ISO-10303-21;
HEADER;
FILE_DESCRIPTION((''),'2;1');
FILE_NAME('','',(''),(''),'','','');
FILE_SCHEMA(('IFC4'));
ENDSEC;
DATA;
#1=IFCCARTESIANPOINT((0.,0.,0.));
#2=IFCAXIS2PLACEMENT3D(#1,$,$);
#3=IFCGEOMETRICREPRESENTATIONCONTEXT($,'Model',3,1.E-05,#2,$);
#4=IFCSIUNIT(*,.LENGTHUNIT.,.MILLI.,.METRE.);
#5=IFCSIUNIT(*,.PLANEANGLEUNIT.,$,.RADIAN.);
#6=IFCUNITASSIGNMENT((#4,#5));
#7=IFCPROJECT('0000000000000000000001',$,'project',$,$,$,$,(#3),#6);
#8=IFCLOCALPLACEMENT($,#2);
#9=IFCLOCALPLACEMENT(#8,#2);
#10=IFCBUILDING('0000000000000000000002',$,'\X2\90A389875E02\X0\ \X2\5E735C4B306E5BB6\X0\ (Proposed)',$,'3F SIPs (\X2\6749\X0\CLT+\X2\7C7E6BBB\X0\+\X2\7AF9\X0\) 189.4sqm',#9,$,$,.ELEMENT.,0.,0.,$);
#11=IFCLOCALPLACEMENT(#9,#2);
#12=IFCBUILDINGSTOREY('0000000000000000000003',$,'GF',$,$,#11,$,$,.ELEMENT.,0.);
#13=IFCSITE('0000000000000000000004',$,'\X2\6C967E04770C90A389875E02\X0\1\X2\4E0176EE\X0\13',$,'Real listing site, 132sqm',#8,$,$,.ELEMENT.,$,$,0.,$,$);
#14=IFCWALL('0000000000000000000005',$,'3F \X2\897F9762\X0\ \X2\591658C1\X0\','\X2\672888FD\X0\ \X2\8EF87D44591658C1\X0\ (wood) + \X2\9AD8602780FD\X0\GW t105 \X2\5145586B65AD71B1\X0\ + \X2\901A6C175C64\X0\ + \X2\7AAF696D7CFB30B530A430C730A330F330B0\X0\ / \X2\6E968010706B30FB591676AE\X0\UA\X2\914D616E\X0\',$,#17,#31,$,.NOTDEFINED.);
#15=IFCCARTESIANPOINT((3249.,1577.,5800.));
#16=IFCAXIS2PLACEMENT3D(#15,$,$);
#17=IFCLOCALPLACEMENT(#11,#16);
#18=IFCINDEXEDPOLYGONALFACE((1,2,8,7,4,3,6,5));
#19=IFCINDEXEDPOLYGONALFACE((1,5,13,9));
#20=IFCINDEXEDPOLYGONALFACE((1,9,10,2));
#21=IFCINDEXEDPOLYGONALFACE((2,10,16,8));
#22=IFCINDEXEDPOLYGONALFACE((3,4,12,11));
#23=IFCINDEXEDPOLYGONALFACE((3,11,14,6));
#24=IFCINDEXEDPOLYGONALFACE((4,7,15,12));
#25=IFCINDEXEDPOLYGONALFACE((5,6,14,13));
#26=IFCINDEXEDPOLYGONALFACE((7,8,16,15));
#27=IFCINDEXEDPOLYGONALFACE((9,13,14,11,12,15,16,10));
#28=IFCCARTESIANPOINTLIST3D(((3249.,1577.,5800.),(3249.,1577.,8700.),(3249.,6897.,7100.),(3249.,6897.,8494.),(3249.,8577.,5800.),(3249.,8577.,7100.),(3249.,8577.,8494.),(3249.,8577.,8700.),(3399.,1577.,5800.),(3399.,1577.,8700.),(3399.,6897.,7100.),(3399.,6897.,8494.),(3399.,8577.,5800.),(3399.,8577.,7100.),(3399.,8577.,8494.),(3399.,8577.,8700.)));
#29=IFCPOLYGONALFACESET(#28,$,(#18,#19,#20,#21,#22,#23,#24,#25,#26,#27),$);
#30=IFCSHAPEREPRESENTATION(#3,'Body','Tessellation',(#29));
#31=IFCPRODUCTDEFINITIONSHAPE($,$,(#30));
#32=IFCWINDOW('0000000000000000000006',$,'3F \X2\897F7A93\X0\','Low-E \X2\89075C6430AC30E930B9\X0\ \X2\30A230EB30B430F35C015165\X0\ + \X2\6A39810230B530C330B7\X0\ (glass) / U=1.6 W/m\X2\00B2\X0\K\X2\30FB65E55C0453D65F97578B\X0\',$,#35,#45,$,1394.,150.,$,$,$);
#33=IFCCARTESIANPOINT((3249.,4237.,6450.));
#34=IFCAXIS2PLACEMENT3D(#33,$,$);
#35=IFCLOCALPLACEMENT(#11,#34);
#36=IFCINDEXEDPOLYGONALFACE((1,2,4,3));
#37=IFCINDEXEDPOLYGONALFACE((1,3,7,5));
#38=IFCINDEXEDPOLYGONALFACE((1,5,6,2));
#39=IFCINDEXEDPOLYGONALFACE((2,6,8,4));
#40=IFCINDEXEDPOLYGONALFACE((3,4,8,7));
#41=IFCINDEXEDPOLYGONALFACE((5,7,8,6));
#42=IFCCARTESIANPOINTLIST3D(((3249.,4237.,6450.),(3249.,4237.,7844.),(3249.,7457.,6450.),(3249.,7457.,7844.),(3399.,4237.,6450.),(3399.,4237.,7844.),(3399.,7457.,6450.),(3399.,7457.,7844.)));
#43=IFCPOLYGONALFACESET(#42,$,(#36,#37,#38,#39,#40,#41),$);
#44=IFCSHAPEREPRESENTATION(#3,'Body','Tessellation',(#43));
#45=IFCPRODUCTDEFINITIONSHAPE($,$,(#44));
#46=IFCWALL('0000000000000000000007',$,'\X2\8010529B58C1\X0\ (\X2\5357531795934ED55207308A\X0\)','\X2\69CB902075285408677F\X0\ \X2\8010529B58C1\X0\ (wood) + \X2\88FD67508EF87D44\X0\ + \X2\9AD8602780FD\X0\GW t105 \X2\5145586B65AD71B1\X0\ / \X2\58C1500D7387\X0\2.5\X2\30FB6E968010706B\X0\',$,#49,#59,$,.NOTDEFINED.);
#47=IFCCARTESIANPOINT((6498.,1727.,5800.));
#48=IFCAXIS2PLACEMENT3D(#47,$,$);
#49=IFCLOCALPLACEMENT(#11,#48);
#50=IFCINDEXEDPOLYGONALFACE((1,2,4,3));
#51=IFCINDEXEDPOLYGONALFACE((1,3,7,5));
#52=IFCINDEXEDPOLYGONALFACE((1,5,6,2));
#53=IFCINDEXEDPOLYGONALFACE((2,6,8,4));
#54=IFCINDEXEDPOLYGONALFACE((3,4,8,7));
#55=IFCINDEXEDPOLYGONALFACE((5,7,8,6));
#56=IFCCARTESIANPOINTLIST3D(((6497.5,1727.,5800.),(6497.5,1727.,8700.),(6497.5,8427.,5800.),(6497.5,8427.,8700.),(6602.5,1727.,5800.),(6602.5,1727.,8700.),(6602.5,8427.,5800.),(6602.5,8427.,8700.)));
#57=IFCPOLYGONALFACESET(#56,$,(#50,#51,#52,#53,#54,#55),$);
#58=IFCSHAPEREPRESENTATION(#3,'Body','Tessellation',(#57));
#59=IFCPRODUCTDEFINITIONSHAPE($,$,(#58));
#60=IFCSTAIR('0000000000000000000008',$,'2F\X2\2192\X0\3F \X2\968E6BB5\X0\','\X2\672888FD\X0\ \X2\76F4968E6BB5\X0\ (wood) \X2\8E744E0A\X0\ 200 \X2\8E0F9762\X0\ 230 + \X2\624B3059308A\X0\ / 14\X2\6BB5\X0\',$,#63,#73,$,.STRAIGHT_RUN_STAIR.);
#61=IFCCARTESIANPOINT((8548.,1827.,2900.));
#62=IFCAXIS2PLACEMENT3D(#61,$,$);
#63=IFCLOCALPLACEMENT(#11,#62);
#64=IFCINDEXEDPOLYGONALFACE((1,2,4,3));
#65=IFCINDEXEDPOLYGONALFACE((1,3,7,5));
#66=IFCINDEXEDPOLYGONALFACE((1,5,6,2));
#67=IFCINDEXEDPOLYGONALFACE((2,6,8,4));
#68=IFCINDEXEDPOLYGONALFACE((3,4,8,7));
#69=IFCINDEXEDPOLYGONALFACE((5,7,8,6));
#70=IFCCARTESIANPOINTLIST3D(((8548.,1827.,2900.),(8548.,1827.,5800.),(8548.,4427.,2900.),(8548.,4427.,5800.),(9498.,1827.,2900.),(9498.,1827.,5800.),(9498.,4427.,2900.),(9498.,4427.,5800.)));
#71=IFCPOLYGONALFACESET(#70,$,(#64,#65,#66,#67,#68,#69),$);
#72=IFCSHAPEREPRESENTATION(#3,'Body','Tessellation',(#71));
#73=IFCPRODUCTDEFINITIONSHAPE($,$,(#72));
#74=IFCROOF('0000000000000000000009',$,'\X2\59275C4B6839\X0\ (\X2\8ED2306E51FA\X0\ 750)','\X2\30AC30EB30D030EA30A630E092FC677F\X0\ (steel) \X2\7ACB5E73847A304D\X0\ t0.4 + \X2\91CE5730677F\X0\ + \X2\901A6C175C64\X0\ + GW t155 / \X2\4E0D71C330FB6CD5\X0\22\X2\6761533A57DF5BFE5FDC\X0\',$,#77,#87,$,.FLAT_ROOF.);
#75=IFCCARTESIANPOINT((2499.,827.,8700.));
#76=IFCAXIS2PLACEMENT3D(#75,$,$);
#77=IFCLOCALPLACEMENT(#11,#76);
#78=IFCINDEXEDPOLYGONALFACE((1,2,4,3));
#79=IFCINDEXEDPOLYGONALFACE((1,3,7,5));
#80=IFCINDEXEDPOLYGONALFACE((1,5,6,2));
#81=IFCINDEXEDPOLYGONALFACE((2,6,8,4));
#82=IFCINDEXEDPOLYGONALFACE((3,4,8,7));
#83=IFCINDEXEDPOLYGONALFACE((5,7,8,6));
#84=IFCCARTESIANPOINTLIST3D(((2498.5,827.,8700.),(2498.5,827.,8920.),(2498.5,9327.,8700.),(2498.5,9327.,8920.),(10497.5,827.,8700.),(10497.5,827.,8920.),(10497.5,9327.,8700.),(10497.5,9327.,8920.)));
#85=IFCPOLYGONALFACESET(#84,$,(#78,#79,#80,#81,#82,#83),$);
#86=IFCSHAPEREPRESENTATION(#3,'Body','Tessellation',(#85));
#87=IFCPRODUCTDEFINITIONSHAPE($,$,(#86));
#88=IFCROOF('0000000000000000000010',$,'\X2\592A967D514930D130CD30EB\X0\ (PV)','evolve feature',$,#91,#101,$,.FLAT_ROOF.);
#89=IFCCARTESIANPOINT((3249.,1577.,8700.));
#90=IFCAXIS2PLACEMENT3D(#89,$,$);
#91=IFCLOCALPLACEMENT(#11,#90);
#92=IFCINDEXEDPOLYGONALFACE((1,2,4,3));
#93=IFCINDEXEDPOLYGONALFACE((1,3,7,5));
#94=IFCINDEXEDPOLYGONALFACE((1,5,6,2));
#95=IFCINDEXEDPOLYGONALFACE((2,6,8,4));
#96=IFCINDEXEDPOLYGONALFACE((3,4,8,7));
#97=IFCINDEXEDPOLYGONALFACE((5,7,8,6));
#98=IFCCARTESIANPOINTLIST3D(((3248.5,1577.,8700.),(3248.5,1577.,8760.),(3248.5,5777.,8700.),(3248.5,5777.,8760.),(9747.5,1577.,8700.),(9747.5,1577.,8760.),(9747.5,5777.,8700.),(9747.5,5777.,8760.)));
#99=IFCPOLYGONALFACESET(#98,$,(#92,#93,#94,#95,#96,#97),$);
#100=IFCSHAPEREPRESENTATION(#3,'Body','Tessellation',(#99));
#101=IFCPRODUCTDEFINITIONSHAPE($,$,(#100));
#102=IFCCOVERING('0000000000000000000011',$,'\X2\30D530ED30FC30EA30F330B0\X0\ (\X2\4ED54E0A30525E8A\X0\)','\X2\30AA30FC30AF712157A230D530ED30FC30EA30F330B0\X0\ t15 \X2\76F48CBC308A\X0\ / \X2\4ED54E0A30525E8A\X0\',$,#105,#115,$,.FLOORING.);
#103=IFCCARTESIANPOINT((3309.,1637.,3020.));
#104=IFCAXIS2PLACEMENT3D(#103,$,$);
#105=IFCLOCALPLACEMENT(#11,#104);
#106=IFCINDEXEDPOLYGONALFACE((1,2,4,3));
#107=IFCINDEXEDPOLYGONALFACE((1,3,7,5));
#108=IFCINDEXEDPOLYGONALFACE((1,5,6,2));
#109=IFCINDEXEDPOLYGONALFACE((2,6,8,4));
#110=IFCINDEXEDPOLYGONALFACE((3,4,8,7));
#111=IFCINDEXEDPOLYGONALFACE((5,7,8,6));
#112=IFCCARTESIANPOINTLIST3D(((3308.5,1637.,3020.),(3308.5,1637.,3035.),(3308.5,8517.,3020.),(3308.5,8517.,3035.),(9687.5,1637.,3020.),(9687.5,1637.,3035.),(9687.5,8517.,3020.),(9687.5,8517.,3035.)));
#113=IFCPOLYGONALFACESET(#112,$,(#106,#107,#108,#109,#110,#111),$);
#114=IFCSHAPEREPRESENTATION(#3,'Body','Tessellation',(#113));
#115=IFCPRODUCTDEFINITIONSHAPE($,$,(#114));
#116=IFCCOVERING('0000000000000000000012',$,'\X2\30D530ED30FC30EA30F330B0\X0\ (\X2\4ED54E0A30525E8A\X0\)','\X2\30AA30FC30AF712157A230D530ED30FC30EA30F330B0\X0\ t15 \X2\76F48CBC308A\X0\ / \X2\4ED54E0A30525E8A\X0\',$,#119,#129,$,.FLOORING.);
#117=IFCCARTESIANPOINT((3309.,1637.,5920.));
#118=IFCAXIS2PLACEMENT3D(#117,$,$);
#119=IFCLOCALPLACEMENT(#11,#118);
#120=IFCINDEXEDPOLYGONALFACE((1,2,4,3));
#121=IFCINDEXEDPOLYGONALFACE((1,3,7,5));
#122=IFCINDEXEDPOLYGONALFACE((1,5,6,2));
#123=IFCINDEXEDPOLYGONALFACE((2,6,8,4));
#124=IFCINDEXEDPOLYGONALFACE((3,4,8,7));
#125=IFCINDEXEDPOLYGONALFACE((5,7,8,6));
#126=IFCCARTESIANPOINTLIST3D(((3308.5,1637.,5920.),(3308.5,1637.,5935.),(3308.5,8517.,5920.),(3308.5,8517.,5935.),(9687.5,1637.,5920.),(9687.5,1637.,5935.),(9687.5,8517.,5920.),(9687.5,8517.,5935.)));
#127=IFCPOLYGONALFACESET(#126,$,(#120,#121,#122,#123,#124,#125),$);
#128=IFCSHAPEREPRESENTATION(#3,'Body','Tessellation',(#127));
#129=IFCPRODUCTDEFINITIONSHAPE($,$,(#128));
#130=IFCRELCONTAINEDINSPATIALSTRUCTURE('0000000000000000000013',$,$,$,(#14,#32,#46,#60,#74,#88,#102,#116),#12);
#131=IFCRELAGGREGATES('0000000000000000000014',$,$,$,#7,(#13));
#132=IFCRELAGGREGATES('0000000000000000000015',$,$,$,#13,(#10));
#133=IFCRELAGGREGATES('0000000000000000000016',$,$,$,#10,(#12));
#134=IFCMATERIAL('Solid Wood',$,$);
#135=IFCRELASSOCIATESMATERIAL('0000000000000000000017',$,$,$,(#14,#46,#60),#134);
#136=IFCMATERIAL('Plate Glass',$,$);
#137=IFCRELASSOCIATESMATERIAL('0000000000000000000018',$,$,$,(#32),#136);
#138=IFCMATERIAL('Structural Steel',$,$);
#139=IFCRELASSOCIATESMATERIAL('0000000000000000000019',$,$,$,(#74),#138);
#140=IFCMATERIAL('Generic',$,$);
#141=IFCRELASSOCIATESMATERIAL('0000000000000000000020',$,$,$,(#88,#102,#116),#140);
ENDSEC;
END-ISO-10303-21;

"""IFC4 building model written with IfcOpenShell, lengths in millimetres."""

from ifc_helpers import new_model, si_unit, frame, frame_2d, origin, place, context, project, spatial, rectangle, extrude, material, element, fill, save


model = new_model("IFC4")

# Units and contexts
model_context = context("Model", 3, precision=1e-05, world=origin())
ifc_project = project(units=[si_unit("LENGTHUNIT", "METRE", prefix="MILLI"), si_unit("PLANEANGLEUNIT", "RADIAN")], contexts=[model_context])

# Site, building, storey
site_placement = place(None, origin())
site = spatial("IfcSite", under=ifc_project, at=site_placement, Name="沖縄県那覇市1丁目13", ObjectType="Real listing site, 132sqm", CompositionType="ELEMENT", RefElevation=0.0)
building_placement = place(site_placement, origin())
building = spatial("IfcBuilding", under=site, at=building_placement, Name="那覇市 平屋の家 (Proposed)", ObjectType="3F SIPs (杉CLT+籾殻+竹) 189.4sqm", CompositionType="ELEMENT", ElevationOfRefHeight=0.0, ElevationOfTerrain=0.0)
storey_placement = place(building_placement, origin())
storey = spatial("IfcBuildingStorey", under=building, at=storey_placement, Name="GF", CompositionType="ELEMENT", Elevation=0.0)

# Shared definitions
ifc_material_1 = material(Name="Solid Wood")

# Shared definitions
ifc_material_2 = material(Name="Plate Glass")

# Shared definitions
ifc_material_3 = material(Name="Generic")

# Wall, opening, window
wall_1_placement = place(storey_placement, frame((3249.0, 1577.0, 5800.0)))
wall_1 = element("IfcWall", 1, at=wall_1_placement, inside=storey, material=ifc_material_1, Name="3F 西面 外壁", Description="木製 軸組外壁 (wood) + 高性能GW t105 充填断熱 + 通気層 + 窯業系サイディング / 準耐火・外皮UA配慮", PredefinedType="NOTDEFINED", context=model_context, shape_type="SweptSolid", body=[
    extrude(rectangle(XDim=150.0, YDim=7000.0, at=frame_2d((75.0, 3500.0))), frame((3249.0, 1577.0, 5800.0)), (0.0, 0.0, 1.0), 2900.0),
])
opening_1_placement = place(storey_placement, frame((3249.0, 4237.0, 6450.0)))
opening_1 = element("IfcOpeningElement", 2, at=opening_1_placement, cuts=wall_1, PredefinedType="NOTDEFINED", context=model_context, shape_type="SweptSolid", body=[
    extrude(rectangle(XDim=150.0, YDim=3220.0, at=frame_2d((75.0, 1610.0))), frame((3249.0, 4237.0, 6450.0)), (0.0, 0.0, 1.0), 1394.0),
])
window_1_placement = place(storey_placement, frame((3249.0, 4237.0, 6450.0)))
window_1 = element("IfcWindow", 3, at=window_1_placement, inside=storey, material=ifc_material_2, Name="3F 西窓", Description="Low-E 複層ガラス アルゴン封入 + 樹脂サッシ (glass) / U=1.6 W/m²K・日射取得型", OverallHeight=1394.0, OverallWidth=150.0, context=model_context, shape_type="SweptSolid", body=[
    extrude(rectangle(XDim=150.0, YDim=3220.0, at=frame_2d((75.0, 1610.0))), frame((3249.0, 4237.0, 6450.0)), (0.0, 0.0, 1.0), 1394.0),
])
fill(opening_1, window_1)

# Wall
wall_2_placement = place(storey_placement, frame((6498.0, 1727.0, 5800.0)))
element("IfcWall", 4, at=wall_2_placement, inside=storey, material=ifc_material_1, Name="耐力壁 (南北間仕切り)", Description="構造用合板 耐力壁 (wood) + 製材軸組 + 高性能GW t105 充填断熱 / 壁倍率2.5・準耐火", PredefinedType="NOTDEFINED", context=model_context, shape_type="SweptSolid", body=[
    extrude(rectangle(XDim=105.0, YDim=6700.0, at=frame_2d((52.0, 3350.0))), frame((6498.0, 1727.0, 5800.0)), (0.0, 0.0, 1.0), 2900.0),
])

# Stair
stair_placement = place(storey_placement, frame((8548.0, 1827.0, 2900.0)))
element("IfcStair", 5, at=stair_placement, inside=storey, material=ifc_material_1, Name="2F→3F 階段", Description="木製 直階段 (wood) 蹴上 200 踏面 230 + 手すり / 14段", PredefinedType="STRAIGHT_RUN_STAIR", context=model_context, shape_type="SweptSolid", body=[
    extrude(rectangle(XDim=950.0, YDim=2600.0, at=frame_2d((475.0, 1300.0))), frame((8548.0, 1827.0, 2900.0)), (0.0, 0.0, 1.0), 2900.0),
])

# Roofs
ifc_material_4 = material(Name="Structural Steel")
roof_1_placement = place(storey_placement, frame((2499.0, 827.0, 8700.0)))
element("IfcRoof", 6, at=roof_1_placement, inside=storey, material=ifc_material_4, Name="大屋根 (軒の出 750)", Description="ガルバリウム鋼板 (steel) 立平葺き t0.4 + 野地板 + 通気層 + GW t155 / 不燃・法22条区域対応", PredefinedType="FLAT_ROOF", context=model_context, shape_type="SweptSolid", body=[
    extrude(rectangle(XDim=7999.0, YDim=8500.0, at=frame_2d((3999.0, 4250.0))), frame((2499.0, 827.0, 8700.0)), (0.0, 0.0, 1.0), 220.0),
])
roof_2_placement = place(storey_placement, frame((3249.0, 1577.0, 8700.0)))
element("IfcRoof", 7, at=roof_2_placement, inside=storey, material=ifc_material_3, Name="太陽光パネル (PV)", Description="evolve feature", PredefinedType="FLAT_ROOF", context=model_context, shape_type="SweptSolid", body=[
    extrude(rectangle(XDim=6499.0, YDim=4200.0, at=frame_2d((3249.0, 2100.0))), frame((3249.0, 1577.0, 8700.0)), (0.0, 0.0, 1.0), 60.0),
])

# Coverings
covering_1_placement = place(storey_placement, frame((3309.0, 1637.0, 3020.0)))
element("IfcCovering", 8, at=covering_1_placement, inside=storey, material=ifc_material_3, Name="フローリング (仕上げ床)", Description="オーク無垢フローリング t15 直貼り / 仕上げ床", PredefinedType="FLOORING", context=model_context, shape_type="SweptSolid", body=[
    extrude(rectangle(XDim=6379.0, YDim=6880.0, at=frame_2d((3189.0, 3440.0))), frame((3309.0, 1637.0, 3020.0)), (0.0, 0.0, 1.0), 15.0),
])
covering_2_placement = place(storey_placement, frame((3309.0, 1637.0, 5920.0)))
element("IfcCovering", 9, at=covering_2_placement, inside=storey, material=ifc_material_3, Name="フローリング (仕上げ床)", Description="オーク無垢フローリング t15 直貼り / 仕上げ床", PredefinedType="FLOORING", context=model_context, shape_type="SweptSolid", body=[
    extrude(rectangle(XDim=6379.0, YDim=6880.0, at=frame_2d((3189.0, 3440.0))), frame((3309.0, 1637.0, 5920.0)), (0.0, 0.0, 1.0), 15.0),
])

save(model, "model.ifc")
